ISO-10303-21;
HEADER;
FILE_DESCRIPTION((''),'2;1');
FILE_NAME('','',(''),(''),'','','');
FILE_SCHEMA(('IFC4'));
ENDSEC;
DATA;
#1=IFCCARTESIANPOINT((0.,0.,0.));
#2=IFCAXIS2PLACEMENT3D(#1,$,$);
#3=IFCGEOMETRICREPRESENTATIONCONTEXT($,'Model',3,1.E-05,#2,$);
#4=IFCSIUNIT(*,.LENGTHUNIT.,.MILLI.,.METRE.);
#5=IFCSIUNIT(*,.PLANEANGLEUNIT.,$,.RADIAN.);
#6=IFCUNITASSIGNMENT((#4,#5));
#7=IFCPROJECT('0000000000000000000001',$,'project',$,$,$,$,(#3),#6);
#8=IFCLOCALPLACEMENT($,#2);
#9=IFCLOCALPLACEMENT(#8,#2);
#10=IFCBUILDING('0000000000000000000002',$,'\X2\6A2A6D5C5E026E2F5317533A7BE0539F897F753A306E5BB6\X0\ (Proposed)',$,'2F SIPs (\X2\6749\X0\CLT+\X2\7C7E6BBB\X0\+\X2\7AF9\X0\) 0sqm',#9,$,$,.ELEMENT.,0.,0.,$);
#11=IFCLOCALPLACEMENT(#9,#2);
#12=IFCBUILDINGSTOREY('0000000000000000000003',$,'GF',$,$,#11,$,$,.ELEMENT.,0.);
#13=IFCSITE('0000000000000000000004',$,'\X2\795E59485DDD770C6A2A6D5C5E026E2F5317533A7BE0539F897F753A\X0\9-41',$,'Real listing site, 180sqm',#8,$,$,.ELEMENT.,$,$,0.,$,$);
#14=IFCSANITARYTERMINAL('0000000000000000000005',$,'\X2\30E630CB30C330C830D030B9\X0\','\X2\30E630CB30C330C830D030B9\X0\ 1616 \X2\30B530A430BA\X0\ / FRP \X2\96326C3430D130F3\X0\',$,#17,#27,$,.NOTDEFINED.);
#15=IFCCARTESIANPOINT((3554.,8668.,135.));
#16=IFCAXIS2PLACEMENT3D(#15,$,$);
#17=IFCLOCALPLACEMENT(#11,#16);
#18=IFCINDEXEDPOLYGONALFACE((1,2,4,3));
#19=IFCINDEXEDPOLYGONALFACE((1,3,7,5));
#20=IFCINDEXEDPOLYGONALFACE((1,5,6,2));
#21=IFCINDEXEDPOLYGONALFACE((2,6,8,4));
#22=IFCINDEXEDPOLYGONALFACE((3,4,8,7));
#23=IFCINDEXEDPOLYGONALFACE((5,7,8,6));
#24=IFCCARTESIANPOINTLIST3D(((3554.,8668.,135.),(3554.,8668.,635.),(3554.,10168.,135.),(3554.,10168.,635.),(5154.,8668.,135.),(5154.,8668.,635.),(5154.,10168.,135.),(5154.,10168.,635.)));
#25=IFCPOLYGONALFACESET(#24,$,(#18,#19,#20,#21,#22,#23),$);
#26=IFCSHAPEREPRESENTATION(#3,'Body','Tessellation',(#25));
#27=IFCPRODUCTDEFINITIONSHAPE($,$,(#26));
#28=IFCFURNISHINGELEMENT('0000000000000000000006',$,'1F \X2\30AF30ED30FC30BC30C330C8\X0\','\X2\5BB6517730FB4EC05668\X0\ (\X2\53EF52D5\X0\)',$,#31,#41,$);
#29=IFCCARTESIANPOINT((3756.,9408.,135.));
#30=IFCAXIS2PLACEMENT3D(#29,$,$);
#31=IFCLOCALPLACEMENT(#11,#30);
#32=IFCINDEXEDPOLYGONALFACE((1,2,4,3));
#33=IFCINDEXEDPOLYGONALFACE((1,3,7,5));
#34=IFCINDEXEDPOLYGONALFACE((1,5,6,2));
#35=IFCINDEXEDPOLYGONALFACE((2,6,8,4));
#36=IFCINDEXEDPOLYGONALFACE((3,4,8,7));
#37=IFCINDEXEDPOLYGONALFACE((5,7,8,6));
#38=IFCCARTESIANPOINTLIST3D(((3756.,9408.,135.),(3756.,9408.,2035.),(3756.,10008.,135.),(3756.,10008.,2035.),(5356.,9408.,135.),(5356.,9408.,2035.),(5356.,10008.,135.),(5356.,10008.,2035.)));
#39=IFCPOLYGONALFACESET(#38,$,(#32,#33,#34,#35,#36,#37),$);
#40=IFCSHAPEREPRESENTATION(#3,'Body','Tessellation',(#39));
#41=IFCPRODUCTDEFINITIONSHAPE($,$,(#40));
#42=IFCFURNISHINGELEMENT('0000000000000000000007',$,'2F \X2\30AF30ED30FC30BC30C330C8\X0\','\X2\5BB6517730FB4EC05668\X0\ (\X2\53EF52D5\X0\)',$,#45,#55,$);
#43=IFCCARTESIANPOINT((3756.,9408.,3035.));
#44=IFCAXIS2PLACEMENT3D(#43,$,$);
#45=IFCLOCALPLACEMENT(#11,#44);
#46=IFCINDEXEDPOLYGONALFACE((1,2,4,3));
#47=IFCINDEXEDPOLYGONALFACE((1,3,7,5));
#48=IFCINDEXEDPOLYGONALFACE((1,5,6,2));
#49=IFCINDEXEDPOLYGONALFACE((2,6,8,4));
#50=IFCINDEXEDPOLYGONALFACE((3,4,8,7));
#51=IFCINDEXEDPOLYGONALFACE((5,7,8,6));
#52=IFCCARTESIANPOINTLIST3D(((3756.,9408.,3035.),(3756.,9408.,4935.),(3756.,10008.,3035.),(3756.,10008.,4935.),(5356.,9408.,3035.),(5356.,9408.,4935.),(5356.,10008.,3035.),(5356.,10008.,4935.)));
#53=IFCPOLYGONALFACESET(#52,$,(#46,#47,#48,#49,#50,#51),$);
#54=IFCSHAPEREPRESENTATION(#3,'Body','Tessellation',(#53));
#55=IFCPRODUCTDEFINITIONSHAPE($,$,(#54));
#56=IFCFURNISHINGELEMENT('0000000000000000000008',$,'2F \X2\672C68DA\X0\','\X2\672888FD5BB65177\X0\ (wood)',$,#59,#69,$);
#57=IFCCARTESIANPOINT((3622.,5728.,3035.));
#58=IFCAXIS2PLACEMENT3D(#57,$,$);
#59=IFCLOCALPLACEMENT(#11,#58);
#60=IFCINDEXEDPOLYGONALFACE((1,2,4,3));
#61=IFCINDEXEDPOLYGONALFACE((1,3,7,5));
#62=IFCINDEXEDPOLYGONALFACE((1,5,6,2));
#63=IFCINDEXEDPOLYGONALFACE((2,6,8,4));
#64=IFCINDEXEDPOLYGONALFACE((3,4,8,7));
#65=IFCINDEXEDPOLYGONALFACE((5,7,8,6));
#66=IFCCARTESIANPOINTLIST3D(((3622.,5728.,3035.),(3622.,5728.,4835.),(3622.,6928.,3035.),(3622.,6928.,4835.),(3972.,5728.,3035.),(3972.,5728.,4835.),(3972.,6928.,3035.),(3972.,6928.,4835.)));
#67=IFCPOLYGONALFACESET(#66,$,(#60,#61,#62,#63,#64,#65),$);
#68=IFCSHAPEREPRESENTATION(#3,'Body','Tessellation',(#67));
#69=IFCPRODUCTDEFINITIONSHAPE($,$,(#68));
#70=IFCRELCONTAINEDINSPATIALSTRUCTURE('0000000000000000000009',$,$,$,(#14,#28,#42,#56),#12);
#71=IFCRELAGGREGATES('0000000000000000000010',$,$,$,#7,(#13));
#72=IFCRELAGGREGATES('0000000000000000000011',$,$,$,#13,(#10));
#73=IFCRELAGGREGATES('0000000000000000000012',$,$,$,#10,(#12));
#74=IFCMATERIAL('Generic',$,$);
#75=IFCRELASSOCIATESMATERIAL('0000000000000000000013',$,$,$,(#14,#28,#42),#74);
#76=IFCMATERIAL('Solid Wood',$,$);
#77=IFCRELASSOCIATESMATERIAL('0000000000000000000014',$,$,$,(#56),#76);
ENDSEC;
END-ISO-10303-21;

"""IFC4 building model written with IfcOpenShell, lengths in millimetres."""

from ifc_helpers import new_model, si_unit, frame, frame_2d, origin, place, context, project, spatial, rectangle, extrude, material, element, save


model = new_model("IFC4")

# Units and contexts
model_context = context("Model", 3, precision=1e-05, world=origin())
ifc_project = project(units=[si_unit("LENGTHUNIT", "METRE", prefix="MILLI"), si_unit("PLANEANGLEUNIT", "RADIAN")], contexts=[model_context])

# Site, building, storey
site_placement = place(None, origin())
site = spatial("IfcSite", under=ifc_project, at=site_placement, Name="神奈川県横浜市港北区篠原西町9-41", ObjectType="Real listing site, 180sqm", CompositionType="ELEMENT", RefElevation=0.0)
building_placement = place(site_placement, origin())
building = spatial("IfcBuilding", under=site, at=building_placement, Name="横浜市港北区篠原西町の家 (Proposed)", ObjectType="2F SIPs (杉CLT+籾殻+竹) 0sqm", CompositionType="ELEMENT", ElevationOfRefHeight=0.0, ElevationOfTerrain=0.0)
storey_placement = place(building_placement, origin())
storey = spatial("IfcBuildingStorey", under=building, at=storey_placement, Name="GF", CompositionType="ELEMENT", Elevation=0.0)

# Shared definitions
ifc_material_1 = material(Name="Solid Wood")

# Shared definitions
ifc_material_2 = material(Name="Generic")

# Sanitary terminal
sanitary_terminal_placement = place(storey_placement, frame((3554.0, 8668.0, 135.0)))
element("IfcSanitaryTerminal", 1, at=sanitary_terminal_placement, inside=storey, material=ifc_material_2, Name="ユニットバス", Description="ユニットバス 1616 サイズ / FRP 防水パン", PredefinedType="NOTDEFINED", context=model_context, shape_type="SweptSolid", body=[
    extrude(rectangle(XDim=1600.0, YDim=1500.0, at=frame_2d((800.0, 750.0))), frame((3554.0, 8668.0, 135.0)), (0.0, 0.0, 1.0), 500.0),
])

# Furnishing elements
furnishing_1_placement = place(storey_placement, frame((3756.0, 9408.0, 135.0)))
element("IfcFurnishingElement", 2, at=furnishing_1_placement, inside=storey, material=ifc_material_2, Name="1F クローゼット", Description="家具・什器 (可動)", context=model_context, shape_type="SweptSolid", body=[
    extrude(rectangle(XDim=1600.0, YDim=600.0, at=frame_2d((800.0, 300.0))), frame((3756.0, 9408.0, 135.0)), (0.0, 0.0, 1.0), 1900.0),
])
furnishing_2_placement = place(storey_placement, frame((3756.0, 9408.0, 3035.0)))
element("IfcFurnishingElement", 3, at=furnishing_2_placement, inside=storey, material=ifc_material_2, Name="2F クローゼット", Description="家具・什器 (可動)", context=model_context, shape_type="SweptSolid", body=[
    extrude(rectangle(XDim=1600.0, YDim=600.0, at=frame_2d((800.0, 300.0))), frame((3756.0, 9408.0, 3035.0)), (0.0, 0.0, 1.0), 1900.0),
])
furnishing_3_placement = place(storey_placement, frame((3622.0, 5728.0, 3035.0)))
element("IfcFurnishingElement", 4, at=furnishing_3_placement, inside=storey, material=ifc_material_1, Name="2F 本棚", Description="木製家具 (wood)", context=model_context, shape_type="SweptSolid", body=[
    extrude(rectangle(XDim=350.0, YDim=1200.0, at=frame_2d((175.0, 600.0))), frame((3622.0, 5728.0, 3035.0)), (0.0, 0.0, 1.0), 1800.0),
])

save(model, "model.ifc")
